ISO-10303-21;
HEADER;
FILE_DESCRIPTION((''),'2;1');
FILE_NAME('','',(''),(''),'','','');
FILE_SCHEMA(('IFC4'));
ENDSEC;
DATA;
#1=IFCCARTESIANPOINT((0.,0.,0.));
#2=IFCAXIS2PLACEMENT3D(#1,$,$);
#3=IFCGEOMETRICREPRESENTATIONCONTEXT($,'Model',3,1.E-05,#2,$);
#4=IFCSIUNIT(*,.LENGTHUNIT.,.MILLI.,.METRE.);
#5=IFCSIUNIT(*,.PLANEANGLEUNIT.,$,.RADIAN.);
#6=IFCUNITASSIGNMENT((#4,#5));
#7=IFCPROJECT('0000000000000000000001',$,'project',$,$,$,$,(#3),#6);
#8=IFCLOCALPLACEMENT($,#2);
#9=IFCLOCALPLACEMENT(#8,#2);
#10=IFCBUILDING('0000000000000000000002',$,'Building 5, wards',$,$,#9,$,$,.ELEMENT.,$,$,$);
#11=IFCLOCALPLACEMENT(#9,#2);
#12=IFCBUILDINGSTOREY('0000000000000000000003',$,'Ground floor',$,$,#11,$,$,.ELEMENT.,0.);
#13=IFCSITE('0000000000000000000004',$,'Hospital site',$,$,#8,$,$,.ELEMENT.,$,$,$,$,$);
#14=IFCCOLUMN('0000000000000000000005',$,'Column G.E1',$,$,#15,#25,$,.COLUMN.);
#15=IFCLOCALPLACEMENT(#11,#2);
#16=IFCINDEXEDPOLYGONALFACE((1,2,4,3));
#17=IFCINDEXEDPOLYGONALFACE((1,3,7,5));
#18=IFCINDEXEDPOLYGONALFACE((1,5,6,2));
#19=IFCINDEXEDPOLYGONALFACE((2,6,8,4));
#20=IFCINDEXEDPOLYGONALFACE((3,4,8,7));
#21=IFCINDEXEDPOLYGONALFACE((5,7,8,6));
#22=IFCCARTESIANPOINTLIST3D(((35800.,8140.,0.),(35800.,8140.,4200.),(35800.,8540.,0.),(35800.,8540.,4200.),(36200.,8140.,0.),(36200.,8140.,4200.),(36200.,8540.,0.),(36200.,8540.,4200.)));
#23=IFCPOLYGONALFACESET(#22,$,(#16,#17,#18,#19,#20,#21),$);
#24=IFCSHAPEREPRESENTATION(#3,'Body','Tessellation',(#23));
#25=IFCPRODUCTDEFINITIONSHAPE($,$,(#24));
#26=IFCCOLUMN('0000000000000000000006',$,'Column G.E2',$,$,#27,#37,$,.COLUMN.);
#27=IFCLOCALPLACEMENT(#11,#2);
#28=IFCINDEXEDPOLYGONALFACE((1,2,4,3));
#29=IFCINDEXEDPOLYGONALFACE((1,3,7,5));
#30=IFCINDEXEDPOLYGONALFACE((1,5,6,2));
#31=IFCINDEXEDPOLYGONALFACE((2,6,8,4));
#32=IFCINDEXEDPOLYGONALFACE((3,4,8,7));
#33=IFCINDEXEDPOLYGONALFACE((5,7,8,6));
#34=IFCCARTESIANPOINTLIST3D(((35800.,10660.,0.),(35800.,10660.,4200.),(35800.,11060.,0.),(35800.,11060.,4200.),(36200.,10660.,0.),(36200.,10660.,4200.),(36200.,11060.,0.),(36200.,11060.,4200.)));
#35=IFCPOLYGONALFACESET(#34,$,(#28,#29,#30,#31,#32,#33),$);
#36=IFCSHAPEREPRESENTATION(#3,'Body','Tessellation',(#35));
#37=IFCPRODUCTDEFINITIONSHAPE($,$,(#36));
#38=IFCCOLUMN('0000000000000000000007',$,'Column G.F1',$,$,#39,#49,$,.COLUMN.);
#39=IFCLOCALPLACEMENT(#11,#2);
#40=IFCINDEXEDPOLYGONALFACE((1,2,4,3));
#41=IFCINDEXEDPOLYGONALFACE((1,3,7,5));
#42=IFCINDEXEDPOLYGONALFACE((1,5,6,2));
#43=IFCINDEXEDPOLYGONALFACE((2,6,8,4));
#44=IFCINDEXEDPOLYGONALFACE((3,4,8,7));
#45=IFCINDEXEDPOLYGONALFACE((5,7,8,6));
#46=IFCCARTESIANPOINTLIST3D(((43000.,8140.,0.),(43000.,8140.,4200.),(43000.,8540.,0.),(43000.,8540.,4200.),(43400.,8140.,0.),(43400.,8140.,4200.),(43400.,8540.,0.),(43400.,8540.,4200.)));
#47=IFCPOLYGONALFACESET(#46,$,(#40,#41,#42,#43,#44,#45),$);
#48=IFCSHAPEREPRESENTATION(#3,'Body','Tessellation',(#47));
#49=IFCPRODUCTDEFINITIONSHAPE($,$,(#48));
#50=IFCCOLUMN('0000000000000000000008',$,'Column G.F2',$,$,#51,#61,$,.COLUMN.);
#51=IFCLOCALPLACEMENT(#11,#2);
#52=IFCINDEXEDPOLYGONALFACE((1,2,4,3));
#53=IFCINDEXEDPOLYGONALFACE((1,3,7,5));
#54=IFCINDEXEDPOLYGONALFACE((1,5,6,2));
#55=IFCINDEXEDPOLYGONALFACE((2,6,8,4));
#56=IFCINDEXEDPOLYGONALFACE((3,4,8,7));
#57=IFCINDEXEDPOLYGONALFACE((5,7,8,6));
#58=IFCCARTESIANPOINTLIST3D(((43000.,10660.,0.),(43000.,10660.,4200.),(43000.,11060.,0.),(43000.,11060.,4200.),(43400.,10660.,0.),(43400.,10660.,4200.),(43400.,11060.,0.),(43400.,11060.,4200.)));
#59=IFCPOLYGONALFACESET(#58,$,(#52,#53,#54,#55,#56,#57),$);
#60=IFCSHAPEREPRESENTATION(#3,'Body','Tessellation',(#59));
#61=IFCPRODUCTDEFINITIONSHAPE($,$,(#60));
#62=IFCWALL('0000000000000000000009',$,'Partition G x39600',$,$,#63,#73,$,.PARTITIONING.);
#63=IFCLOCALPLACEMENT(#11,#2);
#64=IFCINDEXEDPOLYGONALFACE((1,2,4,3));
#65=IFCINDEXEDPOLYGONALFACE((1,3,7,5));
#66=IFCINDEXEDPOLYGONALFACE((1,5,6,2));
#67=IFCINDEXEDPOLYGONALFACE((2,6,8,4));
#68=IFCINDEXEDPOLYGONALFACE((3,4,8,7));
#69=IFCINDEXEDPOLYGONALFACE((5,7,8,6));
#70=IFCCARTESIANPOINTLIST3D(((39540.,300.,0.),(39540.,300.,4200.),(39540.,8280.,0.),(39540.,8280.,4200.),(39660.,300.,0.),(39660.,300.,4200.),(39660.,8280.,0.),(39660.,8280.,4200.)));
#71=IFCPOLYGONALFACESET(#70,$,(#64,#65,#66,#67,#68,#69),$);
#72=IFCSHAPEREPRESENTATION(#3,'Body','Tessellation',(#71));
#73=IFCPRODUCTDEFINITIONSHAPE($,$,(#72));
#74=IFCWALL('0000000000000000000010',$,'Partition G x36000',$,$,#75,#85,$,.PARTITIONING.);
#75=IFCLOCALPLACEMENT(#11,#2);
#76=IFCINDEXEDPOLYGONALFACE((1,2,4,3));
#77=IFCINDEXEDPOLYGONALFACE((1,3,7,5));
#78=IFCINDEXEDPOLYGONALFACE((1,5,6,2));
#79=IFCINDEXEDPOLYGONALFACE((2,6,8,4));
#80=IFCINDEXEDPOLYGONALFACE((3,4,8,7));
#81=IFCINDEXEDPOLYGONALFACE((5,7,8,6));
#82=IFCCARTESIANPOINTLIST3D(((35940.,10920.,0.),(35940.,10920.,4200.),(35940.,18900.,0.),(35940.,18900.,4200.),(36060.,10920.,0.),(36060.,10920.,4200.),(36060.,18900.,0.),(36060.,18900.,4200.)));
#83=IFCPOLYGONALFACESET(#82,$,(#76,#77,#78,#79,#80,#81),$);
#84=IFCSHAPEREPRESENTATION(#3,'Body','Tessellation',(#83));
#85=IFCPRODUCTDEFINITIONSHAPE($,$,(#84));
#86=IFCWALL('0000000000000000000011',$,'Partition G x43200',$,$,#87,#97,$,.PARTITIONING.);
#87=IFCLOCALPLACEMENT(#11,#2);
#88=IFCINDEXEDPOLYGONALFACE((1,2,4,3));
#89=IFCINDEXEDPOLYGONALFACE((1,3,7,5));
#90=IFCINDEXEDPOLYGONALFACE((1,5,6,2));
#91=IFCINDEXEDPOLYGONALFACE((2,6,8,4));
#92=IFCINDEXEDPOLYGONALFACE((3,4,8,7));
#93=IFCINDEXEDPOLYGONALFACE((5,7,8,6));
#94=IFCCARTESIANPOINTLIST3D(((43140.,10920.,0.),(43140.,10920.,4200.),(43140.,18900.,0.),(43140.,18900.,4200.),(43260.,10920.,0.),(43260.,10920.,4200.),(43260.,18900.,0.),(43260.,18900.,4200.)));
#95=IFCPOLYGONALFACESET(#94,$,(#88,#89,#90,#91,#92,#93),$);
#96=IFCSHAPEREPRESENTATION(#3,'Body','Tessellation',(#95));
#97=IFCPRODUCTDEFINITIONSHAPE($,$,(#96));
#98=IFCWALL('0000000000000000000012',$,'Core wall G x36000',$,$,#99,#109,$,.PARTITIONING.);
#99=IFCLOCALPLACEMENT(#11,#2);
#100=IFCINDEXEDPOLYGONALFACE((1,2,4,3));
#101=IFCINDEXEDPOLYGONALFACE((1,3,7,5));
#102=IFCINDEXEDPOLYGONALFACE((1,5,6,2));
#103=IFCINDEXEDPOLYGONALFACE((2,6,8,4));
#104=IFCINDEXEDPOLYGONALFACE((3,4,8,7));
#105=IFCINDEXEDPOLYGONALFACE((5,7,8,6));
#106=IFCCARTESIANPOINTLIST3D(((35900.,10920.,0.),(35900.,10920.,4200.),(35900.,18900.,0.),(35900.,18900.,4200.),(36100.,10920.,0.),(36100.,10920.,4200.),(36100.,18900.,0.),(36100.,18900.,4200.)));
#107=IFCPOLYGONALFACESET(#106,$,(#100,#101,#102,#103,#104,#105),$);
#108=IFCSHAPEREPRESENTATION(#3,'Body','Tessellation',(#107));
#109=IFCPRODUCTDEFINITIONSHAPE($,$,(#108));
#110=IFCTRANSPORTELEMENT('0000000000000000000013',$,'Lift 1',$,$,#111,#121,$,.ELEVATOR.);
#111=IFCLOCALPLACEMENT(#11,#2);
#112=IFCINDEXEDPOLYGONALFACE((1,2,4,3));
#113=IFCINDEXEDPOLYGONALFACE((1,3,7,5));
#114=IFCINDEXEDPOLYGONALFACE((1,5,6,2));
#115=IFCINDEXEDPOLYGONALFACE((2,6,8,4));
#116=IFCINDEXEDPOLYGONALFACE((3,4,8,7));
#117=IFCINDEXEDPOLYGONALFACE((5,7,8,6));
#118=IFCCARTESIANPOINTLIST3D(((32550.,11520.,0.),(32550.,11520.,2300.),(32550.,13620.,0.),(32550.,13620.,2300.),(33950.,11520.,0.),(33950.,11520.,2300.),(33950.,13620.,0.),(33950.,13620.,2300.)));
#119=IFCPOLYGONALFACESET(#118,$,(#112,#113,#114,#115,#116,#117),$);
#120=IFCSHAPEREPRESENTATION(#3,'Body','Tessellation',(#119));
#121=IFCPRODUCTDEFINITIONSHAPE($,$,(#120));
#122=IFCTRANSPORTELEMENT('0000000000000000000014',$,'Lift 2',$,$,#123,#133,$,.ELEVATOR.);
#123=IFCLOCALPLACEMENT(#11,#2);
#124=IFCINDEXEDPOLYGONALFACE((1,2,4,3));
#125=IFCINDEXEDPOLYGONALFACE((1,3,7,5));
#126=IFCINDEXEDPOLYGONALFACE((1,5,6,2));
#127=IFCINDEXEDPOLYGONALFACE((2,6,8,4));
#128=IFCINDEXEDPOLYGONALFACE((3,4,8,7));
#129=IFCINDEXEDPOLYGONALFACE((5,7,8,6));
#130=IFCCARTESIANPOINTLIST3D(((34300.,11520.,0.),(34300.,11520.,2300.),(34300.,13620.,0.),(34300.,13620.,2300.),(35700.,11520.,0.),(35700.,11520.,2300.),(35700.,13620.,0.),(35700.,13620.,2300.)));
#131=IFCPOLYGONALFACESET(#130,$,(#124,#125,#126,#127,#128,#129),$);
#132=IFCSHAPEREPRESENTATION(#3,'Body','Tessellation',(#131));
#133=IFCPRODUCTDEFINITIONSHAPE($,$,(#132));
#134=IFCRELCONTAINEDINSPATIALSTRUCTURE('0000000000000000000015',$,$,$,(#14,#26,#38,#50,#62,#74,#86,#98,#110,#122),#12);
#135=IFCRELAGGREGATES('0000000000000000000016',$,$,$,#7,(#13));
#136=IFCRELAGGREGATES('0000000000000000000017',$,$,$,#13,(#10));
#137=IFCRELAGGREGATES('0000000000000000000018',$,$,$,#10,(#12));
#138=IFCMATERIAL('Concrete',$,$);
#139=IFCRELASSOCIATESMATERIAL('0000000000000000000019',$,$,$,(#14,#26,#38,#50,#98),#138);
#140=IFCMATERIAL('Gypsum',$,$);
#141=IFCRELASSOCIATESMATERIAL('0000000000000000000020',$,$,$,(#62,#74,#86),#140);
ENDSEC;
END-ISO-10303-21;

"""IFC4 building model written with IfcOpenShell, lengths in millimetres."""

from ifc_helpers import new_model, si_unit, frame, frame_2d, origin, origin_2d, place, context, project, spatial, rectangle, extrude, material, element, save


model = new_model("IFC4")

# Units and contexts
model_context = context("Model", 3, precision=1e-05, world=origin())
ifc_project = project(units=[si_unit("LENGTHUNIT", "METRE", prefix="MILLI"), si_unit("PLANEANGLEUNIT", "RADIAN")], contexts=[model_context])

# Site, building, storey
site_placement = place(None, origin())
site = spatial("IfcSite", under=ifc_project, at=site_placement, Name="Hospital site", CompositionType="ELEMENT")
building_placement = place(site_placement, origin())
building = spatial("IfcBuilding", under=site, at=building_placement, Name="Building 5, wards", CompositionType="ELEMENT")
storey_placement = place(building_placement, origin())
storey = spatial("IfcBuildingStorey", under=building, at=storey_placement, Name="Ground floor", CompositionType="ELEMENT", Elevation=0.0)

# Columns
ifc_material_1 = material(Name="Concrete")
for number, where, name in (
    (1, (36000.0, 8340.0, 0.0), "Column G.E1"),
    (2, (36000.0, 10860.0, 0.0), "Column G.E2"),
    (3, (43200.0, 8340.0, 0.0), "Column G.F1"),
    (4, (43200.0, 10860.0, 0.0), "Column G.F2"),
):
    element("IfcColumn", number, at=place(storey_placement, frame(where)), inside=storey, material=ifc_material_1, Name=name, PredefinedType="COLUMN", context=model_context, shape_type="SweptSolid", body=[
        extrude(rectangle(XDim=400.0, YDim=400.0, at=origin_2d()), origin(), (0.0, 0.0, 1.0), 4200.0),
    ])

# Walls
ifc_material_2 = material(Name="Gypsum")
for number, where, x_axis, name in (
    (5, (39660.0, 300.0, 0.0), (0.0, 1.0, 0.0), "Partition G x39600"),
    (6, (36060.0, 10920.0, 0.0), (0.0, 1.0, 0.0), "Partition G x36000"),
    (7, (43260.0, 10920.0, 0.0), (0.0, 1.0, 0.0), "Partition G x43200"),
):
    element("IfcWall", number, at=place(storey_placement, frame(where, x_axis=x_axis)), inside=storey, material=ifc_material_2, Name=name, PredefinedType="PARTITIONING", context=model_context, shape_type="SweptSolid", body=[
        extrude(rectangle(XDim=7980.0, YDim=120.0, at=frame_2d((3990.0, 60.0))), origin(), (0.0, 0.0, 1.0), 4200.0),
    ])
wall_placement = place(storey_placement, frame((36100.0, 10920.0, 0.0), x_axis=(0.0, 1.0, 0.0)))
element("IfcWall", 8, at=wall_placement, inside=storey, material=ifc_material_1, Name="Core wall G x36000", PredefinedType="PARTITIONING", context=model_context, shape_type="SweptSolid", body=[
    extrude(rectangle(XDim=7980.0, YDim=200.0, at=frame_2d((3990.0, 100.0))), origin(), (0.0, 0.0, 1.0), 4200.0),
])

# Transport elements
for number, where, name in (
    (9, (32550.0, 11520.0, 0.0), "Lift 1"),
    (10, (34300.0, 11520.0, 0.0), "Lift 2"),
):
    element("IfcTransportElement", number, at=place(storey_placement, frame(where)), inside=storey, Name=name, PredefinedType="ELEVATOR", context=model_context, shape_type="SweptSolid", body=[
        extrude(rectangle(XDim=1400.0, YDim=2100.0, at=frame_2d((700.0, 1050.0))), origin(), (0.0, 0.0, 1.0), 2300.0),
    ])

save(model, "model.ifc")
